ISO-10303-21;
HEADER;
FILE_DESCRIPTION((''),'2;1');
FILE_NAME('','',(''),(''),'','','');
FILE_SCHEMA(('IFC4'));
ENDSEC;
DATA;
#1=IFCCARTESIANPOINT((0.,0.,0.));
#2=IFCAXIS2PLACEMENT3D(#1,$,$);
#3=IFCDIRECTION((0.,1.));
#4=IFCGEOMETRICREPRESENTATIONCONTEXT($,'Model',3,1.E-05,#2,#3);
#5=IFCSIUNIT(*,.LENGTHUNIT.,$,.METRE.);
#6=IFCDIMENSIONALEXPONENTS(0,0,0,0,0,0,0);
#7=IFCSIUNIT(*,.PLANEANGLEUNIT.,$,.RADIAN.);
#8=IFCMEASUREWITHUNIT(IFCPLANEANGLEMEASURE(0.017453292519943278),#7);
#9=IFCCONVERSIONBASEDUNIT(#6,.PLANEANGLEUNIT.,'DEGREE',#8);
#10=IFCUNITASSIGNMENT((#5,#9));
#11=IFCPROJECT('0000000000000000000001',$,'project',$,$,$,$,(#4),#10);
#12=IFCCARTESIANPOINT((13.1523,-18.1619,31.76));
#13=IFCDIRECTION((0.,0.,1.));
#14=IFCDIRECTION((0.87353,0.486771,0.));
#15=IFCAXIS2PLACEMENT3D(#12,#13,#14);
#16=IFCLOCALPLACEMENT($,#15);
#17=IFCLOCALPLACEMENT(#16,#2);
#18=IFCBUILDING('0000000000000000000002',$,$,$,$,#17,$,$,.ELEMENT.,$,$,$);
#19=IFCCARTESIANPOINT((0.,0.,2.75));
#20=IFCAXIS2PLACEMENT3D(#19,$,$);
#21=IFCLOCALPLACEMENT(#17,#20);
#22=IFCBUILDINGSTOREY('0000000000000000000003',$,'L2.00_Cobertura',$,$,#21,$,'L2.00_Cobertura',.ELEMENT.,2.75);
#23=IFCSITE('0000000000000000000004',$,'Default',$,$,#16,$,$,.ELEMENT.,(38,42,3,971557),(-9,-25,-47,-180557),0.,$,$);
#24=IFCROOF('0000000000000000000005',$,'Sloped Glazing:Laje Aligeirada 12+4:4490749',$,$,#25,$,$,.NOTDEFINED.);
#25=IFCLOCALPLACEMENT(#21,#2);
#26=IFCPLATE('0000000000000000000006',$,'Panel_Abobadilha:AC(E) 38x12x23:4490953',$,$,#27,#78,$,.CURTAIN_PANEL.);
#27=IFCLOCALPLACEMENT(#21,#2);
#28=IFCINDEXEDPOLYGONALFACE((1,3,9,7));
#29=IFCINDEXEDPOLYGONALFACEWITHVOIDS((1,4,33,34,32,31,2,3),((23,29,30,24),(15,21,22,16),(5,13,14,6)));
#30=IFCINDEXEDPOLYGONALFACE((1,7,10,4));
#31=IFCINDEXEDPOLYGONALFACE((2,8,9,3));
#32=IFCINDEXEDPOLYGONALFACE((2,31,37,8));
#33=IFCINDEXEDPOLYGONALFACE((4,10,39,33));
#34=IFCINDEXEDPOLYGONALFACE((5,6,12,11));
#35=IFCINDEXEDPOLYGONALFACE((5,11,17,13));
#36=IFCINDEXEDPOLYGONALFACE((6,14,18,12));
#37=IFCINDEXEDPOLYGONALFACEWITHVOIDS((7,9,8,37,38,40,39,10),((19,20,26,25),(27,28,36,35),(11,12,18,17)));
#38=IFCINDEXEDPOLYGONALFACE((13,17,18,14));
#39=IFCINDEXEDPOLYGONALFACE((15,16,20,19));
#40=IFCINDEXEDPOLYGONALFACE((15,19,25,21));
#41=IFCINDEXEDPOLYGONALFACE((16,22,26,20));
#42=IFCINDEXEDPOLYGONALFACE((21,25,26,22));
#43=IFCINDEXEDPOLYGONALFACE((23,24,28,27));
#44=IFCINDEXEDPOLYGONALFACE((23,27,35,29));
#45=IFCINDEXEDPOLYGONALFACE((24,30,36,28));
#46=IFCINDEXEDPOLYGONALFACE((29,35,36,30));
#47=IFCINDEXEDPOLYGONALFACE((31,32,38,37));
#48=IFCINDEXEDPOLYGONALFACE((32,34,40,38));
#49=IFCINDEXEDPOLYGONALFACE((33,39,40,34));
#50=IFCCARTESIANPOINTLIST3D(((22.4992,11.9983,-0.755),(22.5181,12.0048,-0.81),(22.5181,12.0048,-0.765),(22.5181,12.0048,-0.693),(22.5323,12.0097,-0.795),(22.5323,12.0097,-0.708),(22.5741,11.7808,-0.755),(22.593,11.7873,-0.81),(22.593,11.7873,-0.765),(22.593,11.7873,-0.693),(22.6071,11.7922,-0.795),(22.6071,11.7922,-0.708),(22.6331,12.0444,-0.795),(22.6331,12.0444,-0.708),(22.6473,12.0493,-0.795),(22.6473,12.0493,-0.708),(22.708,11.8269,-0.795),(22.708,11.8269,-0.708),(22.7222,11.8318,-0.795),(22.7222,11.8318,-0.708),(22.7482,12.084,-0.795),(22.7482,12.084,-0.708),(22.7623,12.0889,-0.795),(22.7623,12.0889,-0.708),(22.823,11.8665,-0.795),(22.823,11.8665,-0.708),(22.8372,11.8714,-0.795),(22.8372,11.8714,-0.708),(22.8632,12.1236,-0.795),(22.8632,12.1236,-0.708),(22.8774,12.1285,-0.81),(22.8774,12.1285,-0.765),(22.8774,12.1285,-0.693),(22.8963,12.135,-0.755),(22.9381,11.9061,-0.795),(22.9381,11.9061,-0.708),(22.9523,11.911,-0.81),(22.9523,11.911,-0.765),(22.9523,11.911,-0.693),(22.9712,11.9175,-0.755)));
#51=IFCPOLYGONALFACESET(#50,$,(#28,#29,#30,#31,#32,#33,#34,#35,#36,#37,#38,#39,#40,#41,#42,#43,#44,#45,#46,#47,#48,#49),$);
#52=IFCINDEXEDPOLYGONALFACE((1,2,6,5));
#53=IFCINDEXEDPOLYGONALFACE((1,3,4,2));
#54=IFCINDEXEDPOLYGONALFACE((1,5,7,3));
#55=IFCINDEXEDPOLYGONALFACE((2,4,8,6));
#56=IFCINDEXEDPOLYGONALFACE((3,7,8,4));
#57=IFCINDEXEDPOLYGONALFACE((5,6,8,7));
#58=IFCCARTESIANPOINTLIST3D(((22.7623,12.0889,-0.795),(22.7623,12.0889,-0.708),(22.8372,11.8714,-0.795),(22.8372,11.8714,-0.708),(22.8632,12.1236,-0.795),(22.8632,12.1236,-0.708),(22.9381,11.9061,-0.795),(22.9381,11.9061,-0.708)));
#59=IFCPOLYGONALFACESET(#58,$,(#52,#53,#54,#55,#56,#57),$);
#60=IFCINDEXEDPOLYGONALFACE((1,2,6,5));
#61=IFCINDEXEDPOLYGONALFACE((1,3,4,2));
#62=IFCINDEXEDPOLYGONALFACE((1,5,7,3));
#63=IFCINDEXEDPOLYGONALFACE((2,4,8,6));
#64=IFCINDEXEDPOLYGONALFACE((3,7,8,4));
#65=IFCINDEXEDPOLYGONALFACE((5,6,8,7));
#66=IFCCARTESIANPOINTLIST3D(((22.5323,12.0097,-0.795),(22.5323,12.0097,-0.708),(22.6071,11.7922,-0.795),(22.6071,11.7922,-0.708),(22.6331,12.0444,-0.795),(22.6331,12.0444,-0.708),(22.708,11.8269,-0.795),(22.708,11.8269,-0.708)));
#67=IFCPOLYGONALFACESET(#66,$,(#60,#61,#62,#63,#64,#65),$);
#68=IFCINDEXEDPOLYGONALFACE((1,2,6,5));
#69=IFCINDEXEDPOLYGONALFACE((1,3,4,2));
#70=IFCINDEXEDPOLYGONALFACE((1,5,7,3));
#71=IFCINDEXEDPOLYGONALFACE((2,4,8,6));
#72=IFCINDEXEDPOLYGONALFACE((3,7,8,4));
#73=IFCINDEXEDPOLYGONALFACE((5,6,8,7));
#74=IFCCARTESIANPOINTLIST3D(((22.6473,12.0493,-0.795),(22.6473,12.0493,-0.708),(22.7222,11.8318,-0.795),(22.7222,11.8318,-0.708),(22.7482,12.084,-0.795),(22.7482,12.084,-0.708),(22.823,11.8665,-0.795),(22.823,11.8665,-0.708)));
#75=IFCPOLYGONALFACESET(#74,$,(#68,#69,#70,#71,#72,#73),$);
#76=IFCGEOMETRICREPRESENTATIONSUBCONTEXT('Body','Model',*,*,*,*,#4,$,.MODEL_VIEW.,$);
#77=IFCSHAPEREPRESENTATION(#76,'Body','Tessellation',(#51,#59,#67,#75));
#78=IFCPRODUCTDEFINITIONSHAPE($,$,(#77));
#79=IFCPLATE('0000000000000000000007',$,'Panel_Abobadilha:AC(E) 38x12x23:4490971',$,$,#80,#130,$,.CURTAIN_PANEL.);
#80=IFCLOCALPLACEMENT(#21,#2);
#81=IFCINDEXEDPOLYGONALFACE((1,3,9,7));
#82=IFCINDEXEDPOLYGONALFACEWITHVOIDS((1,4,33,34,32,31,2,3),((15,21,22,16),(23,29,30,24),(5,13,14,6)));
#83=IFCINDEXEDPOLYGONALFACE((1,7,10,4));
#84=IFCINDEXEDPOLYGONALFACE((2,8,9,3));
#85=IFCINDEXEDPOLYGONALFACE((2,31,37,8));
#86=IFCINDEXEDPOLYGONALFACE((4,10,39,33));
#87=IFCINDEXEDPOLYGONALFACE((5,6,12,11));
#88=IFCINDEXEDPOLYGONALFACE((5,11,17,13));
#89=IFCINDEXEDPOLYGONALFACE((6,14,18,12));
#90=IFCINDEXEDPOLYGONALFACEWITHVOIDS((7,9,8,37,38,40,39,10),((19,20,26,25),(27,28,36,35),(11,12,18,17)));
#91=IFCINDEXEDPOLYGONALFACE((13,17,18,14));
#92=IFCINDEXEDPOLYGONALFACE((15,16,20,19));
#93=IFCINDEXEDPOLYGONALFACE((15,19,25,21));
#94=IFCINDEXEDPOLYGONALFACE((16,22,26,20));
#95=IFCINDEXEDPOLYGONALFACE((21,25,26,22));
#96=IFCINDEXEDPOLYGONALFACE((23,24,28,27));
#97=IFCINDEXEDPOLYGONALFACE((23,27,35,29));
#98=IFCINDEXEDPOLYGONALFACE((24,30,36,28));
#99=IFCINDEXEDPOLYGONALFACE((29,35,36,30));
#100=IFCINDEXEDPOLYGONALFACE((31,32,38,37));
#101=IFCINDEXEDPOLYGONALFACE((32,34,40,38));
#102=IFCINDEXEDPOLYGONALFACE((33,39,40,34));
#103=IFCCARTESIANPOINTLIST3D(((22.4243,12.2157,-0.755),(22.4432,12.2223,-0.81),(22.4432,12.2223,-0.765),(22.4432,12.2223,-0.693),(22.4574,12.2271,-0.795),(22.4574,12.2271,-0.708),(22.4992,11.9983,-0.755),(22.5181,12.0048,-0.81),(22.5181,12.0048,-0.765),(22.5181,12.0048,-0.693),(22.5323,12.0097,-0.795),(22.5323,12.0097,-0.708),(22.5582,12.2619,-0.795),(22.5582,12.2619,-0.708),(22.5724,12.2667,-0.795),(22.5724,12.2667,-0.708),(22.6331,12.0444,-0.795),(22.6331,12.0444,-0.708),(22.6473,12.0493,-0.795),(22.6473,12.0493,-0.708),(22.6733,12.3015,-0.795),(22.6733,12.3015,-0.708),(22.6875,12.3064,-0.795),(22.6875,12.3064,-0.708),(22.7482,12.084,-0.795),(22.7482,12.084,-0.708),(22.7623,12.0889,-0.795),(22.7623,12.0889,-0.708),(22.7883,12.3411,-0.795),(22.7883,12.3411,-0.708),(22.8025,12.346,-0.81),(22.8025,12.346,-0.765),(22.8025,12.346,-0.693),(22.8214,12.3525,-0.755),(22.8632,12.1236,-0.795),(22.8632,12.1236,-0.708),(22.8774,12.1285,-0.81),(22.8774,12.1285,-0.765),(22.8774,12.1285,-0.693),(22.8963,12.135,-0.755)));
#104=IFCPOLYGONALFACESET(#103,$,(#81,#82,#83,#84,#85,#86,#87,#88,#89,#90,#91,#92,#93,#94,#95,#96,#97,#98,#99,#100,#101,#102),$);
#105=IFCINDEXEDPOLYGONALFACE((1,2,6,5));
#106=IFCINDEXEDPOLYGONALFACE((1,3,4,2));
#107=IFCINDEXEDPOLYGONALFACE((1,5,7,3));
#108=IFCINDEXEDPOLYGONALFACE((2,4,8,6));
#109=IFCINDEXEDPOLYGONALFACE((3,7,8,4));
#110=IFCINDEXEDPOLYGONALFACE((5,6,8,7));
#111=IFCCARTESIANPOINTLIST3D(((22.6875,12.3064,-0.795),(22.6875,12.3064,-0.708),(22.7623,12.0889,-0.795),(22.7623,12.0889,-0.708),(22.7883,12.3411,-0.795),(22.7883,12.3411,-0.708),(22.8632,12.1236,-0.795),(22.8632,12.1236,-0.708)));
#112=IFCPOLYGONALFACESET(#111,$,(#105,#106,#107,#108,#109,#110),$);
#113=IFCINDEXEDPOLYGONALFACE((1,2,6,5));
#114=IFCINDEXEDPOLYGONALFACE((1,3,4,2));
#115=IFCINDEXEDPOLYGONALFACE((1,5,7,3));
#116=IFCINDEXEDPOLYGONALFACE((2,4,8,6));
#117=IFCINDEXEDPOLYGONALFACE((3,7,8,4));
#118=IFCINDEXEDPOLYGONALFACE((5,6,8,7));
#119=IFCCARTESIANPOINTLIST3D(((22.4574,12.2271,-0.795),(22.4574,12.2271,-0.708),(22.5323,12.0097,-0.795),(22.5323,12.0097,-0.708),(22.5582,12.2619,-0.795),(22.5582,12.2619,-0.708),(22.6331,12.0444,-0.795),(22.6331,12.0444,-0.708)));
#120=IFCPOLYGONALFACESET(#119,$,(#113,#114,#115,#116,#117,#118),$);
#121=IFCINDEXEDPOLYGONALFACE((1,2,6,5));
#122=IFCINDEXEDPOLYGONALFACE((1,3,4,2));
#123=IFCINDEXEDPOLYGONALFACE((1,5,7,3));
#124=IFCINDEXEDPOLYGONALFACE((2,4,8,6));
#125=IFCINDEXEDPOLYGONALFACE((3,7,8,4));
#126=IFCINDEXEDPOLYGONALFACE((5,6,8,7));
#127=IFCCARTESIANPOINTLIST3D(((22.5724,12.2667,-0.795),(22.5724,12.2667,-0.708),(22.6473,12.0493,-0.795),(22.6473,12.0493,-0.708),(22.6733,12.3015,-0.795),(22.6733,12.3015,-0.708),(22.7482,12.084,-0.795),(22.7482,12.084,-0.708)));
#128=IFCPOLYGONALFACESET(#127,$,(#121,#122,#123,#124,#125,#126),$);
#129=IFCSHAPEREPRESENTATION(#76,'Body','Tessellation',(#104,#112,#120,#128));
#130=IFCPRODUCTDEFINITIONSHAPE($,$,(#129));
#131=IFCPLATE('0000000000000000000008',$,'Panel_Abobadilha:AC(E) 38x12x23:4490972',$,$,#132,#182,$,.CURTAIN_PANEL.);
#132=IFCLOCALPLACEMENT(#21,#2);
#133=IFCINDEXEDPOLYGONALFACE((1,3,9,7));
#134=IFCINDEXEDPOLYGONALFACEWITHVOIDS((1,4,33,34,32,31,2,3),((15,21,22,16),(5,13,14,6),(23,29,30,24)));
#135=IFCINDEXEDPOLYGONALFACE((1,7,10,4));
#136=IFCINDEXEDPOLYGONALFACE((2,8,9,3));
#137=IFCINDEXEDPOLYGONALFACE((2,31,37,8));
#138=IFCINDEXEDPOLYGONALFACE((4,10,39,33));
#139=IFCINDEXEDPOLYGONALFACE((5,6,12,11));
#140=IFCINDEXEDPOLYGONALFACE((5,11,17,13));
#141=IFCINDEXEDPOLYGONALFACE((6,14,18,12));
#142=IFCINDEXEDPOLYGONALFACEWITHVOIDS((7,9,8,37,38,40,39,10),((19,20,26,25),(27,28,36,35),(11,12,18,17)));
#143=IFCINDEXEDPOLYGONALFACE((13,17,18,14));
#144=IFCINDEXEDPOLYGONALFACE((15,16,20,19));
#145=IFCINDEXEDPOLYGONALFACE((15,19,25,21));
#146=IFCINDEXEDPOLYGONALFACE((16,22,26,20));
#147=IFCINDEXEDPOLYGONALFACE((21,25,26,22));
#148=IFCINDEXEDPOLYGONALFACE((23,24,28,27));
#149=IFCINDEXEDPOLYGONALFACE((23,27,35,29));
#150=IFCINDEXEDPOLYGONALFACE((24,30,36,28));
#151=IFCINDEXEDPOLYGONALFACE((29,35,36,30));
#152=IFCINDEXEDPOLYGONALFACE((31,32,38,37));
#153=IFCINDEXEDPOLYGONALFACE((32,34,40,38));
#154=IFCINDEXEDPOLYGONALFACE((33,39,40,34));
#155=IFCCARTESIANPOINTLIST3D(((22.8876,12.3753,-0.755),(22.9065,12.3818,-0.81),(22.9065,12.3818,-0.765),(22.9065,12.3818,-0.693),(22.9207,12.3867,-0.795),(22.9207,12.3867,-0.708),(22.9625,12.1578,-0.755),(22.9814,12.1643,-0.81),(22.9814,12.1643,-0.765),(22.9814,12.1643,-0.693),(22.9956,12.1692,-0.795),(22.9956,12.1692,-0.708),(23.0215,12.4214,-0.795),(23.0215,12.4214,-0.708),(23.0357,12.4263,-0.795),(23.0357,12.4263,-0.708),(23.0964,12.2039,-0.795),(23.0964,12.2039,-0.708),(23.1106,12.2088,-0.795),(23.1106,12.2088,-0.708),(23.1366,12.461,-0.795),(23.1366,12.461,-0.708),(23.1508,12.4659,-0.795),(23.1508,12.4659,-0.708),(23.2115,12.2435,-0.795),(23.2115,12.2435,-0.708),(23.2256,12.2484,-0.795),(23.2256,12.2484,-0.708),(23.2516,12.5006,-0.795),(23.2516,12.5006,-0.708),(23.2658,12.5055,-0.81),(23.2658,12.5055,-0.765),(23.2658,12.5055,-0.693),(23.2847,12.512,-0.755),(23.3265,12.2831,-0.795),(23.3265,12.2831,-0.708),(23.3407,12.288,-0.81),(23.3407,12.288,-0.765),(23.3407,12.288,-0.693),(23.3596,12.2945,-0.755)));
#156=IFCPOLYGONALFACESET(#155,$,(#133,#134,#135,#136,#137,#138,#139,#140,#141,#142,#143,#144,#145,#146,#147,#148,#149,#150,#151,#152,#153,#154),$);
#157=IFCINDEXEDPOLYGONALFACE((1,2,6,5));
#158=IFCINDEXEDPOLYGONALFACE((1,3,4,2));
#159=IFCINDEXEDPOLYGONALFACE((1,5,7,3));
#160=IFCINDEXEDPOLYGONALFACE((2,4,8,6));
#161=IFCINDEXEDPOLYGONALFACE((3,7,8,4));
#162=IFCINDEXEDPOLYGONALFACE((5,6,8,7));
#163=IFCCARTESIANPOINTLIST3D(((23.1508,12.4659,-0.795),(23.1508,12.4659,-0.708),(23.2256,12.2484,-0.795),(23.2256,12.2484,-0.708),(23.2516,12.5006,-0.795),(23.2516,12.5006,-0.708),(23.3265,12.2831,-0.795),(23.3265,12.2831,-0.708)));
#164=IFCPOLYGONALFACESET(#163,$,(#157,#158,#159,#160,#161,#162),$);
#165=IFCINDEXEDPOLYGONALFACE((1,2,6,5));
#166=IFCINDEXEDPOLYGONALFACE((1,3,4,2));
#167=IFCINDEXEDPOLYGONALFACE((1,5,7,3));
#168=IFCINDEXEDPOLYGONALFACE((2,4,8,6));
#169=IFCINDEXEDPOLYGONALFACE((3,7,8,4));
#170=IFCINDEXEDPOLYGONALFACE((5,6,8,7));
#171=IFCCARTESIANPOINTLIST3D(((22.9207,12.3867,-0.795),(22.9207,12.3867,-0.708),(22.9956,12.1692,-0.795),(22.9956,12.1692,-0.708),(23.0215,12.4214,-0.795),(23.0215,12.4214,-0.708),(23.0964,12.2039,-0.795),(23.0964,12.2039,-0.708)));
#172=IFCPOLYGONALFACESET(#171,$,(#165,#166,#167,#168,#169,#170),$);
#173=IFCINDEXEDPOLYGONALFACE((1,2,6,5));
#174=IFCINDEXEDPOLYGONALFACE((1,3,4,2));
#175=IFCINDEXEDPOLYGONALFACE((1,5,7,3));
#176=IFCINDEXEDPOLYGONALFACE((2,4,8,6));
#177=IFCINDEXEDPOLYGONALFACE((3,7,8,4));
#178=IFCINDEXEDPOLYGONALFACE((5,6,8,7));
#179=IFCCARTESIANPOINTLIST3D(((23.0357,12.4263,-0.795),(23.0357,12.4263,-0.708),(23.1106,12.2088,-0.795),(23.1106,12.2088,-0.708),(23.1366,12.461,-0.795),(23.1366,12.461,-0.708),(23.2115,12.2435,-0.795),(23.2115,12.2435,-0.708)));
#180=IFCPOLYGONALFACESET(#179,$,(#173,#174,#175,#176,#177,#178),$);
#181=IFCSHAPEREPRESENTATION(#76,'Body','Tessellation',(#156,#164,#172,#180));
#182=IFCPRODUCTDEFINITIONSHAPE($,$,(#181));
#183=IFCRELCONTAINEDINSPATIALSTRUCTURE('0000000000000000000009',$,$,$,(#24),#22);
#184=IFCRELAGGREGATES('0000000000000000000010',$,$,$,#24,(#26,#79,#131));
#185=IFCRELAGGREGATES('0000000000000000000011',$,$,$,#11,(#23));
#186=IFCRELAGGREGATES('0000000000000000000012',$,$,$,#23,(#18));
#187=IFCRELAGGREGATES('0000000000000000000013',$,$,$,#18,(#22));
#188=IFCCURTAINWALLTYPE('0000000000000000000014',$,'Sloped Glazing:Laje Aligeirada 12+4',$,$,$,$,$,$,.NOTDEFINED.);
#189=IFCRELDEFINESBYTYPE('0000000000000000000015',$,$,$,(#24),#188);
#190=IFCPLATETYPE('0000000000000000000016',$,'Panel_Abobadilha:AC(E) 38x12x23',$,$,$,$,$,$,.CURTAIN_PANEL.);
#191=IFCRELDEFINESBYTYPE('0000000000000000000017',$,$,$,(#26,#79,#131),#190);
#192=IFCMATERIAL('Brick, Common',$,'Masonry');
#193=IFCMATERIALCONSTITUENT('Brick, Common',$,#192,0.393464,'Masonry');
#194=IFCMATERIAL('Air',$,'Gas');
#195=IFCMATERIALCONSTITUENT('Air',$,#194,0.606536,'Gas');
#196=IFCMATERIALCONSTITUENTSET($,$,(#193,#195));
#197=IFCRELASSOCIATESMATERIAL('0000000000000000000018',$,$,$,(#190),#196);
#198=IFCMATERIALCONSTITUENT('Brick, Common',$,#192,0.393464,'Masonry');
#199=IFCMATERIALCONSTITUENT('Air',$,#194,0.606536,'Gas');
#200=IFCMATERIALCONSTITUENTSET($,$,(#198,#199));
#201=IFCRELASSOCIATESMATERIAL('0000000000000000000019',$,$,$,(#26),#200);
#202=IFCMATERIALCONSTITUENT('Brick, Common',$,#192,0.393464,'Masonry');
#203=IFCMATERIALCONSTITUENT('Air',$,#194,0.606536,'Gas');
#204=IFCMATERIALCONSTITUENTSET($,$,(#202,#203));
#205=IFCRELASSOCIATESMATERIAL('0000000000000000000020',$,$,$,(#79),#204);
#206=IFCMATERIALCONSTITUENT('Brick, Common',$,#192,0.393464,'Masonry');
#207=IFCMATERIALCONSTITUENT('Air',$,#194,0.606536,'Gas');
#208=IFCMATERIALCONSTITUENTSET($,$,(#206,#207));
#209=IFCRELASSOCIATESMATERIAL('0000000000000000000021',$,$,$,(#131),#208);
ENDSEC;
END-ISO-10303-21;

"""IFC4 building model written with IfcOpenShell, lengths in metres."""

from ifc_helpers import new_model, entity, si_unit, converted_unit, direction, frame, origin, place, context, subcontext, project, spatial, indexed_curve, outline, extrude, source, transform, mapped, material, constituent, constituent_set, type_object, type_shapes, element, aggregate, save


model = new_model("IFC4")

# Units and contexts
model_context = context("Model", 3, precision=1e-05, world=origin(), true_north=direction((0.0, 1.0)))
body_context = subcontext(model_context, "Body", "Model", "MODEL_VIEW")
ifc_project = project(units=[si_unit("LENGTHUNIT", "METRE"), converted_unit("PLANEANGLEUNIT", "DEGREE", entity("IfcPlaneAngleMeasure", 0.017453292519943278), si_unit("PLANEANGLEUNIT", "RADIAN"), dimensions=[0, 0, 0, 0, 0, 0, 0])], contexts=[model_context])

# Site, building, storey
site_placement = place(None, frame((13.1523, -18.1619, 31.76), z_axis=(0.0, 0.0, 1.0), x_axis=(0.87353, 0.486771, 0.0)))
site = spatial("IfcSite", under=ifc_project, at=site_placement, Name="Default", CompositionType="ELEMENT", RefLatitude=(38, 42, 3, 971557), RefLongitude=(-9, -25, -47, -180557), RefElevation=0.0)
building_placement = place(site_placement, origin())
building = spatial("IfcBuilding", under=site, at=building_placement, CompositionType="ELEMENT")
storey_placement = place(building_placement, frame((0.0, 0.0, 2.75)))
storey = spatial("IfcBuildingStorey", under=building, at=storey_placement, Name="L2.00_Cobertura", LongName="L2.00_Cobertura", CompositionType="ELEMENT", Elevation=2.75)

# Roof, plates
curtain_wall_type = type_object("IfcCurtainWallType", Name="Sloped Glazing:Laje Aligeirada 12+4", PredefinedType="NOTDEFINED")
roof_placement = place(storey_placement, frame((0.0, 0.0, -2.75)))
roof = element("IfcRoof", 1, at=roof_placement, inside=storey, type_object=curtain_wall_type, Name="Sloped Glazing:Laje Aligeirada 12+4:4490749", PredefinedType="NOTDEFINED")
ifc_material_1 = material(Name="Brick, Common", Category="Masonry")
ifc_constituent_1 = constituent(ifc_material_1, Name="Brick, Common", Category="Masonry", fraction=0.393464)
ifc_material_2 = material(Name="Air", Category="Gas")
ifc_constituent_2 = constituent(ifc_material_2, Name="Air", Category="Gas", fraction=0.606536)
ifc_constituent_set_1 = constituent_set(constituents=[ifc_constituent_1, ifc_constituent_2])
ifc_constituent_3 = constituent(ifc_material_1, Name="Brick, Common", Category="Masonry", fraction=0.393464)
ifc_constituent_4 = constituent(ifc_material_2, Name="Air", Category="Gas", fraction=0.606536)
ifc_constituent_set_2 = constituent_set(constituents=[ifc_constituent_3, ifc_constituent_4])
plate_type = type_object("IfcPlateType", Name="Panel_Abobadilha:AC(E) 38x12x23", PredefinedType="CURTAIN_PANEL", material=ifc_constituent_set_2)
shared_shape_1 = source(origin(), body_context, "Body", "SweptSolid", [
    extrude(outline(indexed_curve([(-0.19, -0.0543), (0.19, -0.0543), (0.19, -0.0093), (0.21, 0.0007), (0.19, 0.0628), (-0.19, 0.0628), (-0.21, 0.0007), (-0.19, -0.0093), (-0.19, -0.0543)], self_intersect=False), holes=[indexed_curve([(-0.0683, 0.0477), (-0.0683, -0.0393), (-0.175, -0.0393), (-0.175, 0.0477), (-0.0683, 0.0477)], self_intersect=False), indexed_curve([(0.0533, 0.0477), (0.0533, -0.0393), (-0.0533, -0.0393), (-0.0533, 0.0477), (0.0533, 0.0477)], self_intersect=False), indexed_curve([(0.175, 0.0477), (0.175, -0.0393), (0.0683, -0.0393), (0.0683, 0.0477), (0.175, 0.0477)], self_intersect=False)]), frame((0.0, 0.0543, 0.0)), (0.0, 0.0, 1.0), 0.23),
    extrude(outline(indexed_curve([(-0.0533, -0.0435), (0.0533, -0.0435), (0.0533, 0.0435), (-0.0533, 0.0435), (-0.0533, -0.0435)], self_intersect=False)), frame((0.1217, 0.0585, 0.0), z_axis=(0.0, 0.0, 1.0), x_axis=(-1.0, 0.0, 0.0)), (0.0, 0.0, 1.0), 0.23),
    extrude(outline(indexed_curve([(-0.0533, -0.0435), (0.0533, -0.0435), (0.0533, 0.0435), (-0.0533, 0.0435), (-0.0533, -0.0435)], self_intersect=False)), frame((-0.1217, 0.0585, 0.0), z_axis=(0.0, 0.0, 1.0), x_axis=(-1.0, 0.0, 0.0)), (0.0, 0.0, 1.0), 0.23),
    extrude(outline(indexed_curve([(-0.0533, -0.0435), (0.0533, -0.0435), (0.0533, 0.0435), (-0.0533, 0.0435), (-0.0533, -0.0435)], self_intersect=False)), frame((0.0, 0.0585, 0.0), z_axis=(0.0, 0.0, 1.0), x_axis=(-1.0, 0.0, 0.0)), (0.0, 0.0, 1.0), 0.23),
])
type_shapes(plate_type, [shared_shape_1])
plate_1_placement = place(roof_placement, frame((22.6977, 12.0666, 1.94), z_axis=(0.325568, -0.945519, 0.0), x_axis=(0.945519, 0.325568, 0.0)))
plate_1 = element("IfcPlate", 2, at=plate_1_placement, type_object=plate_type, material=ifc_constituent_set_1, Name="Panel_Abobadilha:AC(E) 38x12x23:4490953", PredefinedType="CURTAIN_PANEL", context=body_context, shape_type="MappedRepresentation", body=[
    mapped(shared_shape_1, transform((0.0, 0.0, 0.0), scale=1.0)),
])
ifc_constituent_5 = constituent(ifc_material_1, Name="Brick, Common", Category="Masonry", fraction=0.393464)
ifc_constituent_6 = constituent(ifc_material_2, Name="Air", Category="Gas", fraction=0.606536)
ifc_constituent_set_3 = constituent_set(constituents=[ifc_constituent_5, ifc_constituent_6])
plate_2_placement = place(roof_placement, frame((22.6228, 12.2841, 1.94), z_axis=(0.325568, -0.945519, 0.0), x_axis=(0.945519, 0.325568, 0.0)))
plate_2 = element("IfcPlate", 3, at=plate_2_placement, type_object=plate_type, material=ifc_constituent_set_3, Name="Panel_Abobadilha:AC(E) 38x12x23:4490971", PredefinedType="CURTAIN_PANEL", context=body_context, shape_type="MappedRepresentation", body=[
    mapped(shared_shape_1, transform((0.0, 0.0, 0.0), scale=1.0)),
])
ifc_constituent_7 = constituent(ifc_material_1, Name="Brick, Common", Category="Masonry", fraction=0.393464)
ifc_constituent_8 = constituent(ifc_material_2, Name="Air", Category="Gas", fraction=0.606536)
ifc_constituent_set_4 = constituent_set(constituents=[ifc_constituent_7, ifc_constituent_8])
plate_3_placement = place(roof_placement, frame((23.0862, 12.4436, 1.94), z_axis=(0.325568, -0.945519, 0.0), x_axis=(0.945519, 0.325568, 0.0)))
plate_3 = element("IfcPlate", 4, at=plate_3_placement, type_object=plate_type, material=ifc_constituent_set_4, Name="Panel_Abobadilha:AC(E) 38x12x23:4490972", PredefinedType="CURTAIN_PANEL", context=body_context, shape_type="MappedRepresentation", body=[
    mapped(shared_shape_1, transform((0.0, 0.0, 0.0), scale=1.0)),
])
aggregate(roof, [plate_1, plate_2, plate_3])

save(model, "model.ifc")
